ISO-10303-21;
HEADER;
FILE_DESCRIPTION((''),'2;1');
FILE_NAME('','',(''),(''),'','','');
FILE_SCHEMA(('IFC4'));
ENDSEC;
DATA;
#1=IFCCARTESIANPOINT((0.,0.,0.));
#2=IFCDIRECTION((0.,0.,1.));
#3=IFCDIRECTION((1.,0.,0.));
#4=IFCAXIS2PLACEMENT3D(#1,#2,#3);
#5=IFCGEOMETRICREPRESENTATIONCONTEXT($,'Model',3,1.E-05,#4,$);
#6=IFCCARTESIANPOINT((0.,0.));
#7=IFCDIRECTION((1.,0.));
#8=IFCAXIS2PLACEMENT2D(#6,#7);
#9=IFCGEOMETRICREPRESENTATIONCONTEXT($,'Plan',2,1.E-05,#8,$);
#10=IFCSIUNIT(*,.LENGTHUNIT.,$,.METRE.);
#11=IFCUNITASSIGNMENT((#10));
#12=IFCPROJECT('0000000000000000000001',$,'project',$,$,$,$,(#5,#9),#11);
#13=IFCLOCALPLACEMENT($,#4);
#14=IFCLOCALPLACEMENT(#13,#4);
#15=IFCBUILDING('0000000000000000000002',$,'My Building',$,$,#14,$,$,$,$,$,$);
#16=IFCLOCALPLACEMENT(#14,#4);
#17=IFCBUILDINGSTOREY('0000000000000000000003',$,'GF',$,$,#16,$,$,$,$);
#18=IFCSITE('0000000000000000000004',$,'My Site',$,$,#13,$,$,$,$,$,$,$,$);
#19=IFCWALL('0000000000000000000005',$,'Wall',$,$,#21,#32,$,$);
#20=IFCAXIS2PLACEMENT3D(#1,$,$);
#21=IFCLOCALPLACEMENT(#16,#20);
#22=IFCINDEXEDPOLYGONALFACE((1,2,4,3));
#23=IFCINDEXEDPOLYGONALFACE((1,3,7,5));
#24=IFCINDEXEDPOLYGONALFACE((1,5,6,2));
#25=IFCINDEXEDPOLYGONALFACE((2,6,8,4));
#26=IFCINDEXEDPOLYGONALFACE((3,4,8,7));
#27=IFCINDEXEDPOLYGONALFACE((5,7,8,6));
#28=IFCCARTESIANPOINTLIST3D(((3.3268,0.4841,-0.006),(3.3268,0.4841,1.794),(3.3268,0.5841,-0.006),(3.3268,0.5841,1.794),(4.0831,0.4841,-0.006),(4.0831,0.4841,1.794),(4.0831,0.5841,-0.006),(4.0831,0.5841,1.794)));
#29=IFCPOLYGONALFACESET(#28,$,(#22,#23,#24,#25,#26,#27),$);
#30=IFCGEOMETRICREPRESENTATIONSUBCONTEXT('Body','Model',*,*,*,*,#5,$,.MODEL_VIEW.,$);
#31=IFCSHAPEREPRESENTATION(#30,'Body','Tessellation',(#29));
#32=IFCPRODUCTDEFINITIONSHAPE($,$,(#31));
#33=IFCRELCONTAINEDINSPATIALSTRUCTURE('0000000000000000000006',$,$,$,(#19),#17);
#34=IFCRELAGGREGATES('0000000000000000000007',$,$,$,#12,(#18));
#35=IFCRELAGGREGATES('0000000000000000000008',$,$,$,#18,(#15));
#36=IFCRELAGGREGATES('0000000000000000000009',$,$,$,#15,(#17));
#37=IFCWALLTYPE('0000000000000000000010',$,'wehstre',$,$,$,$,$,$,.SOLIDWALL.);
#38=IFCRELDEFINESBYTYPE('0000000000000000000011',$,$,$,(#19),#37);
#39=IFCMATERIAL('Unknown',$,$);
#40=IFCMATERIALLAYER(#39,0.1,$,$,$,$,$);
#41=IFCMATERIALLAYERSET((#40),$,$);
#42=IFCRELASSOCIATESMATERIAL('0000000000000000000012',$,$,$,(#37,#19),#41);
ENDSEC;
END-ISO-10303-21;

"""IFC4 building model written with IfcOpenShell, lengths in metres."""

from ifc_helpers import new_model, si_unit, frame, origin_with_axes, origin_2d_with_axis, place, context, subcontext, project, spatial, line, indexed_curve, outline, extrude, material, layer, layer_set, layer_usage, type_object, element, save


model = new_model("IFC4")

# Units and contexts
model_context = context("Model", 3, precision=1e-05, world=origin_with_axes())
plan_context = context("Plan", 2, precision=1e-05, world=origin_2d_with_axis())
body_context_1 = subcontext(model_context, "Body", "Model", "MODEL_VIEW")
ifc_project = project(units=[si_unit("LENGTHUNIT", "METRE")], contexts=[model_context, plan_context])

# Site, building, storey
site_placement = place(None, origin_with_axes())
site = spatial("IfcSite", under=ifc_project, at=site_placement, Name="My Site")
building_placement = place(site_placement, origin_with_axes())
building = spatial("IfcBuilding", under=site, at=building_placement, Name="My Building")
storey_placement = place(building_placement, origin_with_axes())
storey = spatial("IfcBuildingStorey", under=building, at=storey_placement, Name="GF")

# Shared definitions
ifc_material = material(Name="Unknown")

# Wall
ifc_layer_1 = layer(ifc_material, 0.1)
ifc_layer_set_1 = layer_set([ifc_layer_1])
wall_type_1 = type_object("IfcWallType", Name="wehstre", PredefinedType="SOLIDWALL", material=ifc_layer_set_1)
ifc_layer_usage_1 = layer_usage(ifc_layer_set_1, "AXIS2", "POSITIVE", 0.0)
wall_1_placement = place(storey_placement, frame((3.3268, 0.4841, -0.006), z_axis=(0.0, 0.0, 1.0), x_axis=(1.0, 0.0, 0.0)))
element("IfcWall", 1, at=wall_1_placement, inside=storey, type_object=wall_type_1, material=ifc_layer_usage_1, Name="Wall", context=body_context_1, shape_type="SweptSolid", body=[
    extrude(outline(indexed_curve([(0.0, 0.0), (0.0, 0.1), (0.7563, 0.1), (0.7563, 0.0)], segments=[line(1, 2, 3, 4, 1)])), origin_with_axes(), (0.0, 0.0, 1.0), 1.8),
])

save(model, "model.ifc")
